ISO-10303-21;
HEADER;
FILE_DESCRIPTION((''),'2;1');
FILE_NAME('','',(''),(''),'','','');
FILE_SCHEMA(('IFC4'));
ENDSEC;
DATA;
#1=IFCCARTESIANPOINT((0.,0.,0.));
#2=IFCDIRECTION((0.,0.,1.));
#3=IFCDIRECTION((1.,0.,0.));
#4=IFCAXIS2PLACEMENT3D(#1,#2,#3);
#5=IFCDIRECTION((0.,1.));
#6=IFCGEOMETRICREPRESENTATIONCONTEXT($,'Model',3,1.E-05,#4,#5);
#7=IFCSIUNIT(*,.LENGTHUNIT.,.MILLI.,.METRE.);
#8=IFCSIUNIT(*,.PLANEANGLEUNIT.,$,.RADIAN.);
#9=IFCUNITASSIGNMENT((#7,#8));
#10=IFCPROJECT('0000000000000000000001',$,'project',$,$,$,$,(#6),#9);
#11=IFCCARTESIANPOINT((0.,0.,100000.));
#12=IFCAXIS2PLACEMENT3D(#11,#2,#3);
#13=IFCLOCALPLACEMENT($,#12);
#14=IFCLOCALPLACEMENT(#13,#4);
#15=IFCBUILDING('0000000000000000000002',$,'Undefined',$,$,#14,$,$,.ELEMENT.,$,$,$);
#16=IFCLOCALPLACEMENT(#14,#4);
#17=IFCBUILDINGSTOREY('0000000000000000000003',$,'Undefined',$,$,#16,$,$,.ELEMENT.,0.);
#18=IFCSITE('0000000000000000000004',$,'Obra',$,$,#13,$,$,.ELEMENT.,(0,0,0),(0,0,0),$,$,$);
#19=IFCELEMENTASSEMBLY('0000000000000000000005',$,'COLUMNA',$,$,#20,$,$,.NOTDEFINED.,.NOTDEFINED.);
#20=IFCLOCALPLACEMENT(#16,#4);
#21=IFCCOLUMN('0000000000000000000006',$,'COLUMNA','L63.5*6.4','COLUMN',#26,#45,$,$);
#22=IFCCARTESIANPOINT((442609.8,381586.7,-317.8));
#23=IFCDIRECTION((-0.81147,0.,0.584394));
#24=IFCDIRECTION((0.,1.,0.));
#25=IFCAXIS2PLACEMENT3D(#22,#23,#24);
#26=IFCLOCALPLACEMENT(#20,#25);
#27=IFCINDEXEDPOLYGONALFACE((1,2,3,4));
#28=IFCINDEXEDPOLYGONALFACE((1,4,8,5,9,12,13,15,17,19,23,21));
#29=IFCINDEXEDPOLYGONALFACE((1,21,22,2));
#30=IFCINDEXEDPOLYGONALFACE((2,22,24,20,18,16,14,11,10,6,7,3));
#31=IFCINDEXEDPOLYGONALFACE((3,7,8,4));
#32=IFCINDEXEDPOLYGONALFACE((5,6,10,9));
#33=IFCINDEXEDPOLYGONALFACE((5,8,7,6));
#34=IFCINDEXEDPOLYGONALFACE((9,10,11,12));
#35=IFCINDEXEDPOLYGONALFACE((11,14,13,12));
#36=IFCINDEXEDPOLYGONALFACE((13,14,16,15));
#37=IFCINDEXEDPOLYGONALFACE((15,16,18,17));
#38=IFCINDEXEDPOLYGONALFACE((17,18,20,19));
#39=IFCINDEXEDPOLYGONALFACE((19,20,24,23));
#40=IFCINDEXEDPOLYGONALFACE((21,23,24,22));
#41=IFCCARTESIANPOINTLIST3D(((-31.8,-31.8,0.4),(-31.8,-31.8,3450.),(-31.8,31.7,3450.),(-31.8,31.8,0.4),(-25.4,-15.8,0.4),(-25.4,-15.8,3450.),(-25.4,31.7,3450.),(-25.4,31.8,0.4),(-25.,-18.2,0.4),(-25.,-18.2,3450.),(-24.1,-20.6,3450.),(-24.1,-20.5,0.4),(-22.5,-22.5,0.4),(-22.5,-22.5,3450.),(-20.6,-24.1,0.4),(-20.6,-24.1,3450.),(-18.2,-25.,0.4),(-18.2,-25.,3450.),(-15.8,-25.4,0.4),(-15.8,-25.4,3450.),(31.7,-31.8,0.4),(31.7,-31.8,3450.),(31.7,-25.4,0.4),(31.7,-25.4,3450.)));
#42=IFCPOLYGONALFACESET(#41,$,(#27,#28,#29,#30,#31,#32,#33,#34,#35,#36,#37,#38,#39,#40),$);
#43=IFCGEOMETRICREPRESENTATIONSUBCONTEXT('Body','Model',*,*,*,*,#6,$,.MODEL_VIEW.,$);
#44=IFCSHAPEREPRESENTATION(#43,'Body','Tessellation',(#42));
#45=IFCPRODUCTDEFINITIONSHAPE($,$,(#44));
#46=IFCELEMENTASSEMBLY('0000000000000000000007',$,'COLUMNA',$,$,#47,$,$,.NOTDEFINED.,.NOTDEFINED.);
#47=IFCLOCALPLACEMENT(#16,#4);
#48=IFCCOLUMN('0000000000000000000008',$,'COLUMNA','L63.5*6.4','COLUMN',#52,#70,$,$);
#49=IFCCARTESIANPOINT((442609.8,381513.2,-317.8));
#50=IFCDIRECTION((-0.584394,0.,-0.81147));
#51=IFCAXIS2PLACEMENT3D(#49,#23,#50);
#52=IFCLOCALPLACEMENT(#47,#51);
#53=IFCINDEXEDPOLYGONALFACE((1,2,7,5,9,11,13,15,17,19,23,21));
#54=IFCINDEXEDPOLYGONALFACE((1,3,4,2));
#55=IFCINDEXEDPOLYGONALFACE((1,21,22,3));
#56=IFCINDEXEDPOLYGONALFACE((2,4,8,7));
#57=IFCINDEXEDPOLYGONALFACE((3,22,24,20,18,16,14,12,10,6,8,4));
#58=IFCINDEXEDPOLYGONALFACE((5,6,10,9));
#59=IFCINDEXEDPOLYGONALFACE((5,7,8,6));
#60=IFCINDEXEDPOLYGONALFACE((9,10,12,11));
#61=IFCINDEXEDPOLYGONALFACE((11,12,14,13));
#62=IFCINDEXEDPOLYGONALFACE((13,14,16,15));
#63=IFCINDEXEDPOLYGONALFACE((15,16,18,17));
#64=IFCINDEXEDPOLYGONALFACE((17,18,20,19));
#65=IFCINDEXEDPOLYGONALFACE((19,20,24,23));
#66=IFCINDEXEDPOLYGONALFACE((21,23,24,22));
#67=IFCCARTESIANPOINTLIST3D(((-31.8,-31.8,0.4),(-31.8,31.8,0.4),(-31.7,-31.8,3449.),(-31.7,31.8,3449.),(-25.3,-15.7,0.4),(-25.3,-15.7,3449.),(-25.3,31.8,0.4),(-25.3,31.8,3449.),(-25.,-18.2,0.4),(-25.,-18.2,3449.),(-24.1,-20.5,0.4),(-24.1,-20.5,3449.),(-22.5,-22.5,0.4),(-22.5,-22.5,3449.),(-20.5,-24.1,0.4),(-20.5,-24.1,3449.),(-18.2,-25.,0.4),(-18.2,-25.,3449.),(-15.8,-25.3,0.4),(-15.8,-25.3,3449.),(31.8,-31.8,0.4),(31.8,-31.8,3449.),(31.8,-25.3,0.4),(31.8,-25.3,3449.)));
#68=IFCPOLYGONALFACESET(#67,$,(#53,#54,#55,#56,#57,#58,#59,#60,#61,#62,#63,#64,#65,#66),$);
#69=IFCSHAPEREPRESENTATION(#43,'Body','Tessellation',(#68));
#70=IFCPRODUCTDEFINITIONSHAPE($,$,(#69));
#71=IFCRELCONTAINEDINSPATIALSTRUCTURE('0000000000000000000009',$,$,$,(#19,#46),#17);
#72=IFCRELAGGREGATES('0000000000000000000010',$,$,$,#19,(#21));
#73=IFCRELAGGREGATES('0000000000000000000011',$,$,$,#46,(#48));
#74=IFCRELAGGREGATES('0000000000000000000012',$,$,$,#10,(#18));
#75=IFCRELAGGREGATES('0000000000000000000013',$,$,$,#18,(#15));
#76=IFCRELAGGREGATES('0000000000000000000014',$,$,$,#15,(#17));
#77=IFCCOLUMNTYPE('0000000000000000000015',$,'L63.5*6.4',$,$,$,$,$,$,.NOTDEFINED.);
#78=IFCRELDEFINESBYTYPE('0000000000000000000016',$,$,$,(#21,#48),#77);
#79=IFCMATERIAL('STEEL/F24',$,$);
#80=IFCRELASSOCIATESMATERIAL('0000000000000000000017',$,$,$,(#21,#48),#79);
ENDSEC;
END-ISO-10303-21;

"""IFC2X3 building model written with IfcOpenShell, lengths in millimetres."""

from ifc_helpers import new_model, si_unit, direction, frame, origin_with_axes, origin_2d_with_axis, place, context, subcontext, project, spatial, l_section, extrude, clip, halfspace, material, type_object, element, aggregate, save


model = new_model("IFC2X3")

# Units and contexts
model_context = context("Model", 3, precision=1e-05, world=origin_with_axes(), true_north=direction((0.0, 1.0)))
body_context = subcontext(model_context, "Body", "Model", "MODEL_VIEW")
ifc_project = project(units=[si_unit("LENGTHUNIT", "METRE", prefix="MILLI"), si_unit("PLANEANGLEUNIT", "RADIAN")], contexts=[model_context])

# Site, building, storey
site_placement = place(None, frame((0.0, 0.0, 100000.0), z_axis=(0.0, 0.0, 1.0), x_axis=(1.0, 0.0, 0.0)))
site = spatial("IfcSite", under=ifc_project, at=site_placement, Name="Obra", CompositionType="ELEMENT", RefLatitude=(0, 0, 0), RefLongitude=(0, 0, 0))
building_placement = place(site_placement, origin_with_axes())
building = spatial("IfcBuilding", under=site, at=building_placement, Name="Undefined", CompositionType="ELEMENT")
storey_placement = place(building_placement, origin_with_axes())
storey = spatial("IfcBuildingStorey", under=building, at=storey_placement, Name="Undefined", CompositionType="ELEMENT", Elevation=0.0)

# Element assemblies, columns
ifc_material_1 = material(Name="STEEL/F24")
column_type_1 = type_object("IfcColumnType", Name="L63.5*6.4", PredefinedType="NOTDEFINED")
assembly_1_placement = place(storey_placement, origin_with_axes())
assembly_1 = element("IfcElementAssembly", 1, at=assembly_1_placement, inside=storey, Name="COLUMNA", AssemblyPlace="NOTDEFINED", PredefinedType="NOTDEFINED")
column_1_placement = place(assembly_1_placement, frame((442609.8, 381586.7, -317.8), z_axis=(-0.81147, 0.0, 0.584394), x_axis=(0.0, 1.0, 0.0)))
column_1 = element("IfcColumn", 2, at=column_1_placement, type_object=column_type_1, material=ifc_material_1, Name="COLUMNA", Description="L63.5*6.4", ObjectType="COLUMN", context=body_context, shape_type="Clipping", body=[
    clip(extrude(l_section(Depth=63.5, Width=63.5, Thickness=6.4, FilletRadius=9.6, at=origin_2d_with_axis()), frame((0.0, 0.0, 3450.0), z_axis=(0.0, 0.0, -1.0), x_axis=(0.0, 1.0, 0.0)), (0.0, 0.0, 1.0), 3510.4), halfspace(frame((-31.7, 0.0, 0.4), z_axis=(0.0, 0.0, 1.0), x_axis=(0.0, -1.0, 0.0)), True)),
])
aggregate(assembly_1, [column_1])
assembly_2_placement = place(storey_placement, origin_with_axes())
assembly_2 = element("IfcElementAssembly", 3, at=assembly_2_placement, inside=storey, Name="COLUMNA", AssemblyPlace="NOTDEFINED", PredefinedType="NOTDEFINED")
column_2_placement = place(assembly_2_placement, frame((442609.8, 381513.2, -317.8), z_axis=(-0.81147, 0.0, 0.584394), x_axis=(-0.584394, 0.0, -0.81147)))
column_2 = element("IfcColumn", 4, at=column_2_placement, type_object=column_type_1, material=ifc_material_1, Name="COLUMNA", Description="L63.5*6.4", ObjectType="COLUMN", context=body_context, shape_type="Clipping", body=[
    clip(extrude(l_section(Depth=63.5, Width=63.5, Thickness=6.4, FilletRadius=9.6, at=origin_2d_with_axis()), frame((0.0, 0.0, 3449.0), z_axis=(0.0, 0.0, -1.0), x_axis=(0.0, 1.0, 0.0)), (0.0, 0.0, 1.0), 3509.4), halfspace(frame((0.0, -41.7, 0.4), z_axis=(0.0, 0.0, 1.0), x_axis=(-1.0, 0.0, 0.0)), True)),
])

aggregate(assembly_2, [column_2])

save(model, "model.ifc")
